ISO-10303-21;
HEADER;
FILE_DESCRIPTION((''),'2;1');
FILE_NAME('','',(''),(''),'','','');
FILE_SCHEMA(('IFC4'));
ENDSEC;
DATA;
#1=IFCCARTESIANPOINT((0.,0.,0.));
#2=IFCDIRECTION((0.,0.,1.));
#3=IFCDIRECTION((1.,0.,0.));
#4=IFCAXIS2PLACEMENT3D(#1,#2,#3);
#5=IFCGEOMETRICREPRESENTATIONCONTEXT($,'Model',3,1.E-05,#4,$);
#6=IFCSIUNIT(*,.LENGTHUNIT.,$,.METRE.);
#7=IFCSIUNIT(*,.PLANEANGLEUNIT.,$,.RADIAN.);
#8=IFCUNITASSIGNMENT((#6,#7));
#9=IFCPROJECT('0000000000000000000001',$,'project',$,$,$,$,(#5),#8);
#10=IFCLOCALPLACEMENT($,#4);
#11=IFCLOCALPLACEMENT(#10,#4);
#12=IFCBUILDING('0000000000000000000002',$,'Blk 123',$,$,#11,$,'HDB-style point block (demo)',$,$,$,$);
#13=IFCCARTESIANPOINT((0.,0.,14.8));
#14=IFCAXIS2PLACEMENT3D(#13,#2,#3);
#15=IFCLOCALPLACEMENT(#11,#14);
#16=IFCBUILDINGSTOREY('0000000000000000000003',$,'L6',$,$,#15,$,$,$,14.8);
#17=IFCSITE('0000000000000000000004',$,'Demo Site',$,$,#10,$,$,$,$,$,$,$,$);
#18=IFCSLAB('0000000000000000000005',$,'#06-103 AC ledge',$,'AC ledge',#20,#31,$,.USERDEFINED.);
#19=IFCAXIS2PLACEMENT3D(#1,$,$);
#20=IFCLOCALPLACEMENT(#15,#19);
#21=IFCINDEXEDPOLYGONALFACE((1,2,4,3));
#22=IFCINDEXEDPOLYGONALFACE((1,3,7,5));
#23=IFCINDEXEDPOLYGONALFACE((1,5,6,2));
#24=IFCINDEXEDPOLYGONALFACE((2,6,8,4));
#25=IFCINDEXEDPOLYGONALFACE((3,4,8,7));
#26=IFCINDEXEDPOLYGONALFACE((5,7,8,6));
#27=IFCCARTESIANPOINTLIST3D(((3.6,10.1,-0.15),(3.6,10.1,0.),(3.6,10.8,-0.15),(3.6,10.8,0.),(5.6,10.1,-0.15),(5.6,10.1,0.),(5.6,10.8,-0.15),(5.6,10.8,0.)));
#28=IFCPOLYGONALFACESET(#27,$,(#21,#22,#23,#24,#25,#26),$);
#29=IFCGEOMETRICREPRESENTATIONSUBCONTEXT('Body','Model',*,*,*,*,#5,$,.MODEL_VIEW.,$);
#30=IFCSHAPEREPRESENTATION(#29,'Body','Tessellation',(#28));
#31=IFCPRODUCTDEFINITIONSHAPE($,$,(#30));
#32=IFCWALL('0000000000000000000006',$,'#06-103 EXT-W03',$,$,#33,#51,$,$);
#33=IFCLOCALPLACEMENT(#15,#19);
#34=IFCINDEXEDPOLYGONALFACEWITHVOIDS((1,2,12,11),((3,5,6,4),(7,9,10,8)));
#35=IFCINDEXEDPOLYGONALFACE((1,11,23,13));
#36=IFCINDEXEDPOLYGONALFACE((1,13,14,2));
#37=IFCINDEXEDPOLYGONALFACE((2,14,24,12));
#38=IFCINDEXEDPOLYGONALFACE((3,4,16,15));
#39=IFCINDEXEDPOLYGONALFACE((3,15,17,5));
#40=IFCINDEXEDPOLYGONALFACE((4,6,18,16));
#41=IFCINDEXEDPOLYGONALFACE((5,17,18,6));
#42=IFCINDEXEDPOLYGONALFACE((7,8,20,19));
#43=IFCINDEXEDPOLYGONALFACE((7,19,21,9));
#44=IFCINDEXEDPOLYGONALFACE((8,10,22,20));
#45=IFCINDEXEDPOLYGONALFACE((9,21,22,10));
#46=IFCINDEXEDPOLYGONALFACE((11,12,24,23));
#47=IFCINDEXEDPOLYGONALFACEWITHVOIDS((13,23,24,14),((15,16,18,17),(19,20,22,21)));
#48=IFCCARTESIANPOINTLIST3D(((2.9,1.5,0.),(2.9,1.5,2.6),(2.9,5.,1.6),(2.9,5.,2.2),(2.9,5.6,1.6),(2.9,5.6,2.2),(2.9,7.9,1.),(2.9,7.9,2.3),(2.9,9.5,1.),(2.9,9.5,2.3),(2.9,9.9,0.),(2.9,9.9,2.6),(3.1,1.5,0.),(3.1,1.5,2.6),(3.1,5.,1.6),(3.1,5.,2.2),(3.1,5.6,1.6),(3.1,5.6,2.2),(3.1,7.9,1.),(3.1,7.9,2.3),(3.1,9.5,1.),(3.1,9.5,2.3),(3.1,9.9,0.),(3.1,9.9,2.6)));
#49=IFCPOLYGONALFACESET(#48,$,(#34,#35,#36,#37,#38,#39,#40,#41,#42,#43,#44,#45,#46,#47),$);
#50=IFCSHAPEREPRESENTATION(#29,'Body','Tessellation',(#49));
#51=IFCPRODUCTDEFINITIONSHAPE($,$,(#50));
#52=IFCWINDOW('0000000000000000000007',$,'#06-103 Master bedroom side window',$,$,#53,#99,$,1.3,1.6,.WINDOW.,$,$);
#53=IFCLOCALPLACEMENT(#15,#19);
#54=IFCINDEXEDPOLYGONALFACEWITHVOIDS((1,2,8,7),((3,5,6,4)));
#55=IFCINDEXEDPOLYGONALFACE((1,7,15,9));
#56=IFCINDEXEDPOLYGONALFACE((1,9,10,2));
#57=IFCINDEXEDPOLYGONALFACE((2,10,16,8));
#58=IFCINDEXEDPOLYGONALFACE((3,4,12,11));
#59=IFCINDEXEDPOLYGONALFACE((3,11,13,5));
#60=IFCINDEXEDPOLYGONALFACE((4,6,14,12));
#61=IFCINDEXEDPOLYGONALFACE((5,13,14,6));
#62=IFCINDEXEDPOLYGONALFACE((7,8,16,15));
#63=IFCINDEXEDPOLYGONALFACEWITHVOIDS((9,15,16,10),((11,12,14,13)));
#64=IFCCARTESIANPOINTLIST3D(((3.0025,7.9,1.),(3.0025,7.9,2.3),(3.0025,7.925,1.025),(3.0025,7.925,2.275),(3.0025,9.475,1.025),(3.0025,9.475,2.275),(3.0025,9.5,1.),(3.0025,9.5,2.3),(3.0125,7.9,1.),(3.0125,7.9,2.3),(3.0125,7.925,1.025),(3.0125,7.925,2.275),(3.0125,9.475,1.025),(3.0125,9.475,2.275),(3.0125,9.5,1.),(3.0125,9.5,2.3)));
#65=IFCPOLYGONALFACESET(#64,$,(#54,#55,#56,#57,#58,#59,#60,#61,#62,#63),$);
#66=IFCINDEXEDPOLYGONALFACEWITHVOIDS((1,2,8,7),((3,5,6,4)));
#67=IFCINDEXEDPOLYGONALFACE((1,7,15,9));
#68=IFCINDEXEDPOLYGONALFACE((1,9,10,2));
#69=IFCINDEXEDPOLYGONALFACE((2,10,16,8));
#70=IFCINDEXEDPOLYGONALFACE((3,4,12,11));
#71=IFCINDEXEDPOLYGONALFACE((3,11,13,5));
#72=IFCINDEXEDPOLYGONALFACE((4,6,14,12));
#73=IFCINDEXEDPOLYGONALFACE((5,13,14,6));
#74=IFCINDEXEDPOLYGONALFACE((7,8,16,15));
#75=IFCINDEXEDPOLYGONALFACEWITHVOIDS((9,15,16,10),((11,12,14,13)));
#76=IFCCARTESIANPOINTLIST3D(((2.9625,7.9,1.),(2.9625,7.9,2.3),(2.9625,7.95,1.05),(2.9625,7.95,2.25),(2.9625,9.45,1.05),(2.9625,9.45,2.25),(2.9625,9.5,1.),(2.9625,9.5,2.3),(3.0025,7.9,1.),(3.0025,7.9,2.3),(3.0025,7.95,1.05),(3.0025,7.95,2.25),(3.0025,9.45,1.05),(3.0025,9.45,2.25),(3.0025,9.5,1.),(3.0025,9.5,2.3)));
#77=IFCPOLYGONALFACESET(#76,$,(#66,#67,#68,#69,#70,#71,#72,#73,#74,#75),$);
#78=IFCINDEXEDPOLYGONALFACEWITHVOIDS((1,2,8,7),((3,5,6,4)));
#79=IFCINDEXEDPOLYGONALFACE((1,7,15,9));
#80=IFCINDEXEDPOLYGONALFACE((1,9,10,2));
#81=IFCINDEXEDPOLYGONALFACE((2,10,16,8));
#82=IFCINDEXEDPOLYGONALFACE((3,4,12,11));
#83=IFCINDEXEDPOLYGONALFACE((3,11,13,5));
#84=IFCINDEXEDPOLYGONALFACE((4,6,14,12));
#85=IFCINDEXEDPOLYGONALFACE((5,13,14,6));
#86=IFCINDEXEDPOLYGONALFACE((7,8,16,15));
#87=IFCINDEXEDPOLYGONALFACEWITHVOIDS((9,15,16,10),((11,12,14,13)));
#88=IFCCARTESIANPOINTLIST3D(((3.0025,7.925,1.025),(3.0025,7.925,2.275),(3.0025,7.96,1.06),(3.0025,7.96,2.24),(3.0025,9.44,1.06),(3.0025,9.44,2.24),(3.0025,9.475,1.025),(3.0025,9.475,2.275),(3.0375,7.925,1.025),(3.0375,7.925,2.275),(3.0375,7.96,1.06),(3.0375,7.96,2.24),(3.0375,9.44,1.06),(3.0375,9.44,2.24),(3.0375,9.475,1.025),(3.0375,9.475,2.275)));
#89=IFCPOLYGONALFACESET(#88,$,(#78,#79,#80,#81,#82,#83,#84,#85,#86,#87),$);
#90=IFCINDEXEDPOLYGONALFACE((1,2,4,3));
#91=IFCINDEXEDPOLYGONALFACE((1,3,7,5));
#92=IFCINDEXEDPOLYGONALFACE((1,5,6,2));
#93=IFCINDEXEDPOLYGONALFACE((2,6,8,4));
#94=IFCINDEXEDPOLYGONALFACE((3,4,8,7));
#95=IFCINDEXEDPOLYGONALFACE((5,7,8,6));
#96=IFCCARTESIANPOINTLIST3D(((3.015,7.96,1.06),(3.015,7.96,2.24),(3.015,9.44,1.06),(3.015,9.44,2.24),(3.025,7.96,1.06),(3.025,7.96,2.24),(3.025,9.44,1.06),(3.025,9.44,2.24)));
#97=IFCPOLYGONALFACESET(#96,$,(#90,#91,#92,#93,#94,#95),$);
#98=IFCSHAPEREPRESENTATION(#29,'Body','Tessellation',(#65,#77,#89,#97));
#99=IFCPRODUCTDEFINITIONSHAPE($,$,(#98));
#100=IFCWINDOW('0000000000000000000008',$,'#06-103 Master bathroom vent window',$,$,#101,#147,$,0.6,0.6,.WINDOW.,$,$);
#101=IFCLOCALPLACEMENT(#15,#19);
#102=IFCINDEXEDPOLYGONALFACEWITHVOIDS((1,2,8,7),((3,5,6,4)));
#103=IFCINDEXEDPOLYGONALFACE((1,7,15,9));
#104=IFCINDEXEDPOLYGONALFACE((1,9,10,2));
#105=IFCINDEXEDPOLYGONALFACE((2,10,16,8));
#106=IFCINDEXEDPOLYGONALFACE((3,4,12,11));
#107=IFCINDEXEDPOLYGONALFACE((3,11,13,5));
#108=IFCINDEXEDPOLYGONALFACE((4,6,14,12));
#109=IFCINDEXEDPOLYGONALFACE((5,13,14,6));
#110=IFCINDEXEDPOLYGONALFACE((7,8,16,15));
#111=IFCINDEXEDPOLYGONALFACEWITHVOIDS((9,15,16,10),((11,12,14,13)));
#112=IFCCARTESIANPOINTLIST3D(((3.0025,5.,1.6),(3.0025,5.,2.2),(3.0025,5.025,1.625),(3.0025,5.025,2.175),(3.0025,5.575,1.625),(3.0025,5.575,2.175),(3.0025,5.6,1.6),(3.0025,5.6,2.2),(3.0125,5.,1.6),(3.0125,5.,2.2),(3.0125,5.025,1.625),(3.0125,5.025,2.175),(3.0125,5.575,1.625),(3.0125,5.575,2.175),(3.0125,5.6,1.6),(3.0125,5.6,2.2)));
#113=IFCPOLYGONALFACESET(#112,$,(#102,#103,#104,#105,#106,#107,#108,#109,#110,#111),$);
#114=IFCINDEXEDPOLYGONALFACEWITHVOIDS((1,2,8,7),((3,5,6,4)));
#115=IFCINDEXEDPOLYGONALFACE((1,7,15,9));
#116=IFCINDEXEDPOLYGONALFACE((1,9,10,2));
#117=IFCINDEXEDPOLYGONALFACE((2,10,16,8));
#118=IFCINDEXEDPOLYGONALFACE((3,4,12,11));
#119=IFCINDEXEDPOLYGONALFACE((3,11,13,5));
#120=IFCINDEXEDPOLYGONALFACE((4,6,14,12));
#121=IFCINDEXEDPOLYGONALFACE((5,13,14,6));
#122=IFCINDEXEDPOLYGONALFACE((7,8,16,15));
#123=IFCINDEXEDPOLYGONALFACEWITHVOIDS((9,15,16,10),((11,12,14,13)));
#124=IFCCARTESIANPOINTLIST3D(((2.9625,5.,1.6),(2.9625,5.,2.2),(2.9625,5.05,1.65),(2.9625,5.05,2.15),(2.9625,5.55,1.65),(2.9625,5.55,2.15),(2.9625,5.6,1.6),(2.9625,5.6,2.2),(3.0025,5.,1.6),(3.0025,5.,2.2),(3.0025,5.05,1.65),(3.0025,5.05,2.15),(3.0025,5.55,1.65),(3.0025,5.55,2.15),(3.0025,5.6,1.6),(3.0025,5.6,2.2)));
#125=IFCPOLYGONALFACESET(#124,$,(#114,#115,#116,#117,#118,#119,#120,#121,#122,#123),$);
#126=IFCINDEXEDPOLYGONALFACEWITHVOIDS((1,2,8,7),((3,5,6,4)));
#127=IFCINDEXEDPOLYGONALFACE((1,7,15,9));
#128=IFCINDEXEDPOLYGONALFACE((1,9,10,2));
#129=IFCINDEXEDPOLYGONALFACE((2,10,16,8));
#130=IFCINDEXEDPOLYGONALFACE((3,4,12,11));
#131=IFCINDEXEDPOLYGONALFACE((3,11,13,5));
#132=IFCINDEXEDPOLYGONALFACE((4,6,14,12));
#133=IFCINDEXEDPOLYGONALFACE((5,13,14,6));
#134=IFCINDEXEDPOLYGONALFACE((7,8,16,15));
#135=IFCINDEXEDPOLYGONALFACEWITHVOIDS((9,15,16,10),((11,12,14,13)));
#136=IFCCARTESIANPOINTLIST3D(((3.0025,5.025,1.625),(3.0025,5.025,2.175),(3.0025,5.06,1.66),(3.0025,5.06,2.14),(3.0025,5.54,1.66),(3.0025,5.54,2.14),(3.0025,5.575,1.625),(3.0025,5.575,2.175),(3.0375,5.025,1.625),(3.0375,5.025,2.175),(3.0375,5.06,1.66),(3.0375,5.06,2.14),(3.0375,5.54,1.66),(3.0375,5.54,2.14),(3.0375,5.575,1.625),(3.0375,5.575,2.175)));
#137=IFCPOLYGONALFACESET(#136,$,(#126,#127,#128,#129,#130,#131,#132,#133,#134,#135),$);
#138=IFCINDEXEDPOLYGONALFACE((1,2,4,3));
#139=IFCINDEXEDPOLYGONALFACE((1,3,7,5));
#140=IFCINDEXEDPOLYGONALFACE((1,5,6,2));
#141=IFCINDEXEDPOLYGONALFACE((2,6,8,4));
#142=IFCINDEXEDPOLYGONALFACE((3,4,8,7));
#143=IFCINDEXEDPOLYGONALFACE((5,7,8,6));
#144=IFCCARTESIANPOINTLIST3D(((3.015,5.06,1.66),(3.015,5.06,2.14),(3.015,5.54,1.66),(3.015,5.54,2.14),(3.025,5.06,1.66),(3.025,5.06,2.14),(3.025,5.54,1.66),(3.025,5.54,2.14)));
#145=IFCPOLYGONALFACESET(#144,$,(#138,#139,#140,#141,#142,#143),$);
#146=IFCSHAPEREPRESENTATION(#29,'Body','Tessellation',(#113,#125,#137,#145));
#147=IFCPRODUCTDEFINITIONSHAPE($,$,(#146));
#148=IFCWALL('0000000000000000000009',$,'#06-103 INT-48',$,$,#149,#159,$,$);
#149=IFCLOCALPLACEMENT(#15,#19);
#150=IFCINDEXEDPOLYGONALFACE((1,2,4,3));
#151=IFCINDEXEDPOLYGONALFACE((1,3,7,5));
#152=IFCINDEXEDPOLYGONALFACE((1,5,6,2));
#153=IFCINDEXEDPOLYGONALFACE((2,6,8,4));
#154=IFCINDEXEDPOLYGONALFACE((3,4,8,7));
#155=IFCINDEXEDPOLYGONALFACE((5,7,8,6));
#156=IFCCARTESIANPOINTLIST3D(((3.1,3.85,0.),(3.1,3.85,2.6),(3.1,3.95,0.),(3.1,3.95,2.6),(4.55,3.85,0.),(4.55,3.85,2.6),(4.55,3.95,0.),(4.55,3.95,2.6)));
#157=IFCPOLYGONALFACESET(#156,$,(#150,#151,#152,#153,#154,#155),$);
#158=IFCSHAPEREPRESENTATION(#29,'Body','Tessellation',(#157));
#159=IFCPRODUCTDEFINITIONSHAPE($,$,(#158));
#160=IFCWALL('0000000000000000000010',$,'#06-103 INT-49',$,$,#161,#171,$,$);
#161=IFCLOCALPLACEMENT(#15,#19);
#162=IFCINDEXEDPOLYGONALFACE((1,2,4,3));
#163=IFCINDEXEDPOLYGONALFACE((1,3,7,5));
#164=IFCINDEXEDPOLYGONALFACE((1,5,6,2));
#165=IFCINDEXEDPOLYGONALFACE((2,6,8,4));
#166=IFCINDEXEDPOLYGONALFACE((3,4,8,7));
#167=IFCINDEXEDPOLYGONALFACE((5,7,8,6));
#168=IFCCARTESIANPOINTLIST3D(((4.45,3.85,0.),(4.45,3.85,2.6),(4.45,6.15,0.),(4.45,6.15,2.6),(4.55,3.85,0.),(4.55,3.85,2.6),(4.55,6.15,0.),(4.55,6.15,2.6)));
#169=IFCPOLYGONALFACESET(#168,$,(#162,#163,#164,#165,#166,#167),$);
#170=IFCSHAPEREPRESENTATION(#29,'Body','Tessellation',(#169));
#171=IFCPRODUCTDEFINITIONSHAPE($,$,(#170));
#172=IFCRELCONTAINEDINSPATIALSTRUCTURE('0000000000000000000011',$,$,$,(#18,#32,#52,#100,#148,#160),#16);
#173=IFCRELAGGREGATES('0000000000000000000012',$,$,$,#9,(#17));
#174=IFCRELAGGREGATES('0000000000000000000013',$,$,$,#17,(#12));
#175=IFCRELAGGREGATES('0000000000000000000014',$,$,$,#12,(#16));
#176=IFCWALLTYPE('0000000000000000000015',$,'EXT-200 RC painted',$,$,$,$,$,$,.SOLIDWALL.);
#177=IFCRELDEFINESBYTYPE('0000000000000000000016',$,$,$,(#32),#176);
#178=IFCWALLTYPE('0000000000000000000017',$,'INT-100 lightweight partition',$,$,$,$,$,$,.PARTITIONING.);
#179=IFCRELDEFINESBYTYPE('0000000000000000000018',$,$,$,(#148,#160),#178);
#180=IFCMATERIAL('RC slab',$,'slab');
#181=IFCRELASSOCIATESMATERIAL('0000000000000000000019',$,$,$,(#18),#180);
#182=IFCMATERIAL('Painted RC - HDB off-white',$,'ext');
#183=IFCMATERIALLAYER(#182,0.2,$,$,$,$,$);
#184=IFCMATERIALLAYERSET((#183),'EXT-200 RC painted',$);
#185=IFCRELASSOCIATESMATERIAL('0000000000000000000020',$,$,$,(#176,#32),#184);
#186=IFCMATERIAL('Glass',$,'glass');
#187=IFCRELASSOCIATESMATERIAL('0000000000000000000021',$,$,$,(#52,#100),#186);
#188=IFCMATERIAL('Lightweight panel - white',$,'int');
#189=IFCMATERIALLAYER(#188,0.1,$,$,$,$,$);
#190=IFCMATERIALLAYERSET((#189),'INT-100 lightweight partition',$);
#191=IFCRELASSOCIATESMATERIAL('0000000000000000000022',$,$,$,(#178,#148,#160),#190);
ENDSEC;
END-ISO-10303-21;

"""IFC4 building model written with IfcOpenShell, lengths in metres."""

from ifc_helpers import new_model, si_unit, frame, origin, origin_with_axes, place, context, subcontext, project, spatial, polyline, line, indexed_curve, outline, extrude, material, layer, layer_set, layer_usage, type_object, element, fill, save


model = new_model("IFC4")

# Units and contexts
model_context = context("Model", 3, precision=1e-05, world=origin_with_axes())
body_context = subcontext(model_context, "Body", "Model", "MODEL_VIEW")
ifc_project = project(units=[si_unit("LENGTHUNIT", "METRE"), si_unit("PLANEANGLEUNIT", "RADIAN")], contexts=[model_context])

# Site, building, storey
site_placement = place(None, origin_with_axes())
site = spatial("IfcSite", under=ifc_project, at=site_placement, Name="Demo Site")
building_placement = place(site_placement, origin_with_axes())
building = spatial("IfcBuilding", under=site, at=building_placement, Name="Blk 123", LongName="HDB-style point block (demo)")
storey_placement = place(building_placement, frame((0.0, 0.0, 14.8), z_axis=(0.0, 0.0, 1.0), x_axis=(1.0, 0.0, 0.0)))
storey = spatial("IfcBuildingStorey", under=building, at=storey_placement, Name="L6", Elevation=14.8)

# Slab
ifc_material_1 = material(Name="RC slab", Category="slab")
slab_placement = place(storey_placement, frame((4.6, 10.45, -0.15), z_axis=(0.0, 0.0, 1.0), x_axis=(1.0, 0.0, 0.0)))
element("IfcSlab", 1, at=slab_placement, inside=storey, material=ifc_material_1, Name="#06-103 AC ledge", ObjectType="AC ledge", PredefinedType="USERDEFINED", context=body_context, shape_type="SweptSolid", body=[
    extrude(outline(polyline([(1.0, -0.35), (1.0, 0.35), (-1.0, 0.35), (-1.0, -0.35), (1.0, -0.35)])), origin(), (0.0, 0.0, 1.0), 0.15),
])

# Wall, openings, windows
ifc_material_2 = material(Name="Painted RC - HDB off-white", Category="ext")
ifc_layer_1 = layer(ifc_material_2, 0.2)
ifc_layer_set_1 = layer_set([ifc_layer_1], Name="EXT-200 RC painted")
ifc_layer_usage_1 = layer_usage(ifc_layer_set_1, "AXIS2", "POSITIVE", 0.0)
wall_type_1 = type_object("IfcWallType", Name="EXT-200 RC painted", PredefinedType="SOLIDWALL", material=ifc_layer_set_1)
wall_1_placement = place(storey_placement, frame((2.9, 9.9, 0.0), z_axis=(0.0, 0.0, 1.0), x_axis=(0.0, -1.0, 0.0)))
wall_1 = element("IfcWall", 2, at=wall_1_placement, inside=storey, type_object=wall_type_1, material=ifc_layer_usage_1, Name="#06-103 EXT-W03", context=body_context, shape_type="SweptSolid", body=[
    extrude(outline(indexed_curve([(0.0, 0.0), (0.0, 0.2), (8.4, 0.2), (8.4, 0.0), (0.0, 0.0)], self_intersect=False)), origin_with_axes(), (0.0, 0.0, 1.0), 2.6),
])
opening_1_placement = place(wall_1_placement, frame((0.4, -0.1, 1.0), z_axis=(0.0, 0.0, 1.0), x_axis=(1.0, 0.0, 0.0)))
opening_1 = element("IfcOpeningElement", 3, at=opening_1_placement, cuts=wall_1, context=body_context, shape_type="SweptSolid", body=[
    extrude(outline(indexed_curve([(0.0, 0.0), (0.0, 0.4), (1.6, 0.4), (1.6, 0.0), (0.0, 0.0)], self_intersect=False)), origin_with_axes(), (0.0, 0.0, 1.0), 1.3),
])
opening_2_placement = place(wall_1_placement, frame((4.3, -0.1, 1.6), z_axis=(0.0, 0.0, 1.0), x_axis=(1.0, 0.0, 0.0)))
opening_2 = element("IfcOpeningElement", 4, at=opening_2_placement, cuts=wall_1, context=body_context, shape_type="SweptSolid", body=[
    extrude(outline(indexed_curve([(0.0, 0.0), (0.0, 0.4), (0.6, 0.4), (0.6, 0.0), (0.0, 0.0)], self_intersect=False)), origin_with_axes(), (0.0, 0.0, 1.0), 0.6),
])
ifc_material_3 = material(Name="Glass", Category="glass")
window_1_placement = place(opening_1_placement, frame((0.0, 0.1125, 0.0), z_axis=(0.0, 0.0, 1.0), x_axis=(1.0, 0.0, 0.0)))
window_1 = element("IfcWindow", 5, at=window_1_placement, inside=storey, material=ifc_material_3, Name="#06-103 Master bedroom side window", OverallHeight=1.3, OverallWidth=1.6, PredefinedType="WINDOW", context=body_context, shape_type="SweptSolid", body=[
    extrude(outline(indexed_curve([(0.0, 0.0), (1.6, 0.0), (1.6, 1.3), (0.0, 1.3)], segments=[line(1, 2, 3, 4, 1)]), holes=[indexed_curve([(0.025, 0.025), (1.575, 0.025), (1.575, 1.275), (0.025, 1.275)], segments=[line(1, 2, 3, 4, 1)])]), frame((0.0, 0.09, 0.0), z_axis=(0.0, -1.0, 0.0), x_axis=(1.0, 0.0, 0.0)), (0.0, 0.0, -1.0), 0.01),
    extrude(outline(indexed_curve([(0.0, 0.0), (1.6, 0.0), (1.6, 1.3), (0.0, 1.3)], segments=[line(1, 2, 3, 4, 1)]), holes=[indexed_curve([(0.05, 0.05), (1.55, 0.05), (1.55, 1.25), (0.05, 1.25)], segments=[line(1, 2, 3, 4, 1)])]), frame((0.0, 0.05, 0.0), z_axis=(0.0, -1.0, 0.0), x_axis=(1.0, 0.0, 0.0)), (0.0, 0.0, -1.0), 0.04),
    extrude(outline(indexed_curve([(0.0, 0.0), (1.55, 0.0), (1.55, 1.25), (0.0, 1.25)], segments=[line(1, 2, 3, 4, 1)]), holes=[indexed_curve([(0.035, 0.035), (1.515, 0.035), (1.515, 1.215), (0.035, 1.215)], segments=[line(1, 2, 3, 4, 1)])]), frame((0.025, 0.09, 0.025), z_axis=(0.0, -1.0, 0.0), x_axis=(1.0, 0.0, 0.0)), (0.0, 0.0, -1.0), 0.035),
    extrude(outline(indexed_curve([(0.035, 0.035), (1.515, 0.035), (1.515, 1.215), (0.035, 1.215)], segments=[line(1, 2, 3, 4, 1)])), frame((0.025, 0.1025, 0.025), z_axis=(0.0, -1.0, 0.0), x_axis=(1.0, 0.0, 0.0)), (0.0, 0.0, -1.0), 0.01),
])
fill(opening_1, window_1)
window_2_placement = place(opening_2_placement, frame((0.0, 0.1125, 0.0), z_axis=(0.0, 0.0, 1.0), x_axis=(1.0, 0.0, 0.0)))
window_2 = element("IfcWindow", 6, at=window_2_placement, inside=storey, material=ifc_material_3, Name="#06-103 Master bathroom vent window", OverallHeight=0.6, OverallWidth=0.6, PredefinedType="WINDOW", context=body_context, shape_type="SweptSolid", body=[
    extrude(outline(indexed_curve([(0.0, 0.0), (0.6, 0.0), (0.6, 0.6), (0.0, 0.6)], segments=[line(1, 2, 3, 4, 1)]), holes=[indexed_curve([(0.025, 0.025), (0.575, 0.025), (0.575, 0.575), (0.025, 0.575)], segments=[line(1, 2, 3, 4, 1)])]), frame((0.0, 0.09, 0.0), z_axis=(0.0, -1.0, 0.0), x_axis=(1.0, 0.0, 0.0)), (0.0, 0.0, -1.0), 0.01),
    extrude(outline(indexed_curve([(0.0, 0.0), (0.6, 0.0), (0.6, 0.6), (0.0, 0.6)], segments=[line(1, 2, 3, 4, 1)]), holes=[indexed_curve([(0.05, 0.05), (0.55, 0.05), (0.55, 0.55), (0.05, 0.55)], segments=[line(1, 2, 3, 4, 1)])]), frame((0.0, 0.05, 0.0), z_axis=(0.0, -1.0, 0.0), x_axis=(1.0, 0.0, 0.0)), (0.0, 0.0, -1.0), 0.04),
    extrude(outline(indexed_curve([(0.0, 0.0), (0.55, 0.0), (0.55, 0.55), (0.0, 0.55)], segments=[line(1, 2, 3, 4, 1)]), holes=[indexed_curve([(0.035, 0.035), (0.515, 0.035), (0.515, 0.515), (0.035, 0.515)], segments=[line(1, 2, 3, 4, 1)])]), frame((0.025, 0.09, 0.025), z_axis=(0.0, -1.0, 0.0), x_axis=(1.0, 0.0, 0.0)), (0.0, 0.0, -1.0), 0.035),
    extrude(outline(indexed_curve([(0.035, 0.035), (0.515, 0.035), (0.515, 0.515), (0.035, 0.515)], segments=[line(1, 2, 3, 4, 1)])), frame((0.025, 0.1025, 0.025), z_axis=(0.0, -1.0, 0.0), x_axis=(1.0, 0.0, 0.0)), (0.0, 0.0, -1.0), 0.01),
])
fill(opening_2, window_2)

# Shared definitions
ifc_material_4 = material(Name="Lightweight panel - white", Category="int")
ifc_layer_2 = layer(ifc_material_4, 0.1)
ifc_layer_set_2 = layer_set([ifc_layer_2], Name="INT-100 lightweight partition")
ifc_layer_usage_2 = layer_usage(ifc_layer_set_2, "AXIS2", "POSITIVE", -0.05)
wall_type_2 = type_object("IfcWallType", Name="INT-100 lightweight partition", PredefinedType="PARTITIONING", material=ifc_layer_set_2)

# Walls
wall_2_placement = place(storey_placement, frame((3.1, 3.9, 0.0), z_axis=(0.0, 0.0, 1.0), x_axis=(1.0, 0.0, 0.0)))
element("IfcWall", 7, at=wall_2_placement, inside=storey, type_object=wall_type_2, material=ifc_layer_usage_2, Name="#06-103 INT-48", context=body_context, shape_type="SweptSolid", body=[
    extrude(outline(indexed_curve([(0.0, 0.0), (0.0, 0.1), (1.45, 0.1), (1.45, 0.0), (0.0, 0.0)], self_intersect=False)), frame((0.0, -0.05, 0.0), z_axis=(0.0, 0.0, 1.0), x_axis=(1.0, 0.0, 0.0)), (0.0, 0.0, 1.0), 2.6),
])
wall_3_placement = place(storey_placement, frame((4.5, 3.85, 0.0), z_axis=(0.0, 0.0, 1.0), x_axis=(0.0, 1.0, 0.0)))
element("IfcWall", 8, at=wall_3_placement, inside=storey, type_object=wall_type_2, material=ifc_layer_usage_2, Name="#06-103 INT-49", context=body_context, shape_type="SweptSolid", body=[
    extrude(outline(indexed_curve([(0.0, 0.0), (0.0, 0.1), (2.3, 0.1), (2.3, 0.0), (0.0, 0.0)], self_intersect=False)), frame((0.0, -0.05, 0.0), z_axis=(0.0, 0.0, 1.0), x_axis=(1.0, 0.0, 0.0)), (0.0, 0.0, 1.0), 2.6),
])

save(model, "model.ifc")
